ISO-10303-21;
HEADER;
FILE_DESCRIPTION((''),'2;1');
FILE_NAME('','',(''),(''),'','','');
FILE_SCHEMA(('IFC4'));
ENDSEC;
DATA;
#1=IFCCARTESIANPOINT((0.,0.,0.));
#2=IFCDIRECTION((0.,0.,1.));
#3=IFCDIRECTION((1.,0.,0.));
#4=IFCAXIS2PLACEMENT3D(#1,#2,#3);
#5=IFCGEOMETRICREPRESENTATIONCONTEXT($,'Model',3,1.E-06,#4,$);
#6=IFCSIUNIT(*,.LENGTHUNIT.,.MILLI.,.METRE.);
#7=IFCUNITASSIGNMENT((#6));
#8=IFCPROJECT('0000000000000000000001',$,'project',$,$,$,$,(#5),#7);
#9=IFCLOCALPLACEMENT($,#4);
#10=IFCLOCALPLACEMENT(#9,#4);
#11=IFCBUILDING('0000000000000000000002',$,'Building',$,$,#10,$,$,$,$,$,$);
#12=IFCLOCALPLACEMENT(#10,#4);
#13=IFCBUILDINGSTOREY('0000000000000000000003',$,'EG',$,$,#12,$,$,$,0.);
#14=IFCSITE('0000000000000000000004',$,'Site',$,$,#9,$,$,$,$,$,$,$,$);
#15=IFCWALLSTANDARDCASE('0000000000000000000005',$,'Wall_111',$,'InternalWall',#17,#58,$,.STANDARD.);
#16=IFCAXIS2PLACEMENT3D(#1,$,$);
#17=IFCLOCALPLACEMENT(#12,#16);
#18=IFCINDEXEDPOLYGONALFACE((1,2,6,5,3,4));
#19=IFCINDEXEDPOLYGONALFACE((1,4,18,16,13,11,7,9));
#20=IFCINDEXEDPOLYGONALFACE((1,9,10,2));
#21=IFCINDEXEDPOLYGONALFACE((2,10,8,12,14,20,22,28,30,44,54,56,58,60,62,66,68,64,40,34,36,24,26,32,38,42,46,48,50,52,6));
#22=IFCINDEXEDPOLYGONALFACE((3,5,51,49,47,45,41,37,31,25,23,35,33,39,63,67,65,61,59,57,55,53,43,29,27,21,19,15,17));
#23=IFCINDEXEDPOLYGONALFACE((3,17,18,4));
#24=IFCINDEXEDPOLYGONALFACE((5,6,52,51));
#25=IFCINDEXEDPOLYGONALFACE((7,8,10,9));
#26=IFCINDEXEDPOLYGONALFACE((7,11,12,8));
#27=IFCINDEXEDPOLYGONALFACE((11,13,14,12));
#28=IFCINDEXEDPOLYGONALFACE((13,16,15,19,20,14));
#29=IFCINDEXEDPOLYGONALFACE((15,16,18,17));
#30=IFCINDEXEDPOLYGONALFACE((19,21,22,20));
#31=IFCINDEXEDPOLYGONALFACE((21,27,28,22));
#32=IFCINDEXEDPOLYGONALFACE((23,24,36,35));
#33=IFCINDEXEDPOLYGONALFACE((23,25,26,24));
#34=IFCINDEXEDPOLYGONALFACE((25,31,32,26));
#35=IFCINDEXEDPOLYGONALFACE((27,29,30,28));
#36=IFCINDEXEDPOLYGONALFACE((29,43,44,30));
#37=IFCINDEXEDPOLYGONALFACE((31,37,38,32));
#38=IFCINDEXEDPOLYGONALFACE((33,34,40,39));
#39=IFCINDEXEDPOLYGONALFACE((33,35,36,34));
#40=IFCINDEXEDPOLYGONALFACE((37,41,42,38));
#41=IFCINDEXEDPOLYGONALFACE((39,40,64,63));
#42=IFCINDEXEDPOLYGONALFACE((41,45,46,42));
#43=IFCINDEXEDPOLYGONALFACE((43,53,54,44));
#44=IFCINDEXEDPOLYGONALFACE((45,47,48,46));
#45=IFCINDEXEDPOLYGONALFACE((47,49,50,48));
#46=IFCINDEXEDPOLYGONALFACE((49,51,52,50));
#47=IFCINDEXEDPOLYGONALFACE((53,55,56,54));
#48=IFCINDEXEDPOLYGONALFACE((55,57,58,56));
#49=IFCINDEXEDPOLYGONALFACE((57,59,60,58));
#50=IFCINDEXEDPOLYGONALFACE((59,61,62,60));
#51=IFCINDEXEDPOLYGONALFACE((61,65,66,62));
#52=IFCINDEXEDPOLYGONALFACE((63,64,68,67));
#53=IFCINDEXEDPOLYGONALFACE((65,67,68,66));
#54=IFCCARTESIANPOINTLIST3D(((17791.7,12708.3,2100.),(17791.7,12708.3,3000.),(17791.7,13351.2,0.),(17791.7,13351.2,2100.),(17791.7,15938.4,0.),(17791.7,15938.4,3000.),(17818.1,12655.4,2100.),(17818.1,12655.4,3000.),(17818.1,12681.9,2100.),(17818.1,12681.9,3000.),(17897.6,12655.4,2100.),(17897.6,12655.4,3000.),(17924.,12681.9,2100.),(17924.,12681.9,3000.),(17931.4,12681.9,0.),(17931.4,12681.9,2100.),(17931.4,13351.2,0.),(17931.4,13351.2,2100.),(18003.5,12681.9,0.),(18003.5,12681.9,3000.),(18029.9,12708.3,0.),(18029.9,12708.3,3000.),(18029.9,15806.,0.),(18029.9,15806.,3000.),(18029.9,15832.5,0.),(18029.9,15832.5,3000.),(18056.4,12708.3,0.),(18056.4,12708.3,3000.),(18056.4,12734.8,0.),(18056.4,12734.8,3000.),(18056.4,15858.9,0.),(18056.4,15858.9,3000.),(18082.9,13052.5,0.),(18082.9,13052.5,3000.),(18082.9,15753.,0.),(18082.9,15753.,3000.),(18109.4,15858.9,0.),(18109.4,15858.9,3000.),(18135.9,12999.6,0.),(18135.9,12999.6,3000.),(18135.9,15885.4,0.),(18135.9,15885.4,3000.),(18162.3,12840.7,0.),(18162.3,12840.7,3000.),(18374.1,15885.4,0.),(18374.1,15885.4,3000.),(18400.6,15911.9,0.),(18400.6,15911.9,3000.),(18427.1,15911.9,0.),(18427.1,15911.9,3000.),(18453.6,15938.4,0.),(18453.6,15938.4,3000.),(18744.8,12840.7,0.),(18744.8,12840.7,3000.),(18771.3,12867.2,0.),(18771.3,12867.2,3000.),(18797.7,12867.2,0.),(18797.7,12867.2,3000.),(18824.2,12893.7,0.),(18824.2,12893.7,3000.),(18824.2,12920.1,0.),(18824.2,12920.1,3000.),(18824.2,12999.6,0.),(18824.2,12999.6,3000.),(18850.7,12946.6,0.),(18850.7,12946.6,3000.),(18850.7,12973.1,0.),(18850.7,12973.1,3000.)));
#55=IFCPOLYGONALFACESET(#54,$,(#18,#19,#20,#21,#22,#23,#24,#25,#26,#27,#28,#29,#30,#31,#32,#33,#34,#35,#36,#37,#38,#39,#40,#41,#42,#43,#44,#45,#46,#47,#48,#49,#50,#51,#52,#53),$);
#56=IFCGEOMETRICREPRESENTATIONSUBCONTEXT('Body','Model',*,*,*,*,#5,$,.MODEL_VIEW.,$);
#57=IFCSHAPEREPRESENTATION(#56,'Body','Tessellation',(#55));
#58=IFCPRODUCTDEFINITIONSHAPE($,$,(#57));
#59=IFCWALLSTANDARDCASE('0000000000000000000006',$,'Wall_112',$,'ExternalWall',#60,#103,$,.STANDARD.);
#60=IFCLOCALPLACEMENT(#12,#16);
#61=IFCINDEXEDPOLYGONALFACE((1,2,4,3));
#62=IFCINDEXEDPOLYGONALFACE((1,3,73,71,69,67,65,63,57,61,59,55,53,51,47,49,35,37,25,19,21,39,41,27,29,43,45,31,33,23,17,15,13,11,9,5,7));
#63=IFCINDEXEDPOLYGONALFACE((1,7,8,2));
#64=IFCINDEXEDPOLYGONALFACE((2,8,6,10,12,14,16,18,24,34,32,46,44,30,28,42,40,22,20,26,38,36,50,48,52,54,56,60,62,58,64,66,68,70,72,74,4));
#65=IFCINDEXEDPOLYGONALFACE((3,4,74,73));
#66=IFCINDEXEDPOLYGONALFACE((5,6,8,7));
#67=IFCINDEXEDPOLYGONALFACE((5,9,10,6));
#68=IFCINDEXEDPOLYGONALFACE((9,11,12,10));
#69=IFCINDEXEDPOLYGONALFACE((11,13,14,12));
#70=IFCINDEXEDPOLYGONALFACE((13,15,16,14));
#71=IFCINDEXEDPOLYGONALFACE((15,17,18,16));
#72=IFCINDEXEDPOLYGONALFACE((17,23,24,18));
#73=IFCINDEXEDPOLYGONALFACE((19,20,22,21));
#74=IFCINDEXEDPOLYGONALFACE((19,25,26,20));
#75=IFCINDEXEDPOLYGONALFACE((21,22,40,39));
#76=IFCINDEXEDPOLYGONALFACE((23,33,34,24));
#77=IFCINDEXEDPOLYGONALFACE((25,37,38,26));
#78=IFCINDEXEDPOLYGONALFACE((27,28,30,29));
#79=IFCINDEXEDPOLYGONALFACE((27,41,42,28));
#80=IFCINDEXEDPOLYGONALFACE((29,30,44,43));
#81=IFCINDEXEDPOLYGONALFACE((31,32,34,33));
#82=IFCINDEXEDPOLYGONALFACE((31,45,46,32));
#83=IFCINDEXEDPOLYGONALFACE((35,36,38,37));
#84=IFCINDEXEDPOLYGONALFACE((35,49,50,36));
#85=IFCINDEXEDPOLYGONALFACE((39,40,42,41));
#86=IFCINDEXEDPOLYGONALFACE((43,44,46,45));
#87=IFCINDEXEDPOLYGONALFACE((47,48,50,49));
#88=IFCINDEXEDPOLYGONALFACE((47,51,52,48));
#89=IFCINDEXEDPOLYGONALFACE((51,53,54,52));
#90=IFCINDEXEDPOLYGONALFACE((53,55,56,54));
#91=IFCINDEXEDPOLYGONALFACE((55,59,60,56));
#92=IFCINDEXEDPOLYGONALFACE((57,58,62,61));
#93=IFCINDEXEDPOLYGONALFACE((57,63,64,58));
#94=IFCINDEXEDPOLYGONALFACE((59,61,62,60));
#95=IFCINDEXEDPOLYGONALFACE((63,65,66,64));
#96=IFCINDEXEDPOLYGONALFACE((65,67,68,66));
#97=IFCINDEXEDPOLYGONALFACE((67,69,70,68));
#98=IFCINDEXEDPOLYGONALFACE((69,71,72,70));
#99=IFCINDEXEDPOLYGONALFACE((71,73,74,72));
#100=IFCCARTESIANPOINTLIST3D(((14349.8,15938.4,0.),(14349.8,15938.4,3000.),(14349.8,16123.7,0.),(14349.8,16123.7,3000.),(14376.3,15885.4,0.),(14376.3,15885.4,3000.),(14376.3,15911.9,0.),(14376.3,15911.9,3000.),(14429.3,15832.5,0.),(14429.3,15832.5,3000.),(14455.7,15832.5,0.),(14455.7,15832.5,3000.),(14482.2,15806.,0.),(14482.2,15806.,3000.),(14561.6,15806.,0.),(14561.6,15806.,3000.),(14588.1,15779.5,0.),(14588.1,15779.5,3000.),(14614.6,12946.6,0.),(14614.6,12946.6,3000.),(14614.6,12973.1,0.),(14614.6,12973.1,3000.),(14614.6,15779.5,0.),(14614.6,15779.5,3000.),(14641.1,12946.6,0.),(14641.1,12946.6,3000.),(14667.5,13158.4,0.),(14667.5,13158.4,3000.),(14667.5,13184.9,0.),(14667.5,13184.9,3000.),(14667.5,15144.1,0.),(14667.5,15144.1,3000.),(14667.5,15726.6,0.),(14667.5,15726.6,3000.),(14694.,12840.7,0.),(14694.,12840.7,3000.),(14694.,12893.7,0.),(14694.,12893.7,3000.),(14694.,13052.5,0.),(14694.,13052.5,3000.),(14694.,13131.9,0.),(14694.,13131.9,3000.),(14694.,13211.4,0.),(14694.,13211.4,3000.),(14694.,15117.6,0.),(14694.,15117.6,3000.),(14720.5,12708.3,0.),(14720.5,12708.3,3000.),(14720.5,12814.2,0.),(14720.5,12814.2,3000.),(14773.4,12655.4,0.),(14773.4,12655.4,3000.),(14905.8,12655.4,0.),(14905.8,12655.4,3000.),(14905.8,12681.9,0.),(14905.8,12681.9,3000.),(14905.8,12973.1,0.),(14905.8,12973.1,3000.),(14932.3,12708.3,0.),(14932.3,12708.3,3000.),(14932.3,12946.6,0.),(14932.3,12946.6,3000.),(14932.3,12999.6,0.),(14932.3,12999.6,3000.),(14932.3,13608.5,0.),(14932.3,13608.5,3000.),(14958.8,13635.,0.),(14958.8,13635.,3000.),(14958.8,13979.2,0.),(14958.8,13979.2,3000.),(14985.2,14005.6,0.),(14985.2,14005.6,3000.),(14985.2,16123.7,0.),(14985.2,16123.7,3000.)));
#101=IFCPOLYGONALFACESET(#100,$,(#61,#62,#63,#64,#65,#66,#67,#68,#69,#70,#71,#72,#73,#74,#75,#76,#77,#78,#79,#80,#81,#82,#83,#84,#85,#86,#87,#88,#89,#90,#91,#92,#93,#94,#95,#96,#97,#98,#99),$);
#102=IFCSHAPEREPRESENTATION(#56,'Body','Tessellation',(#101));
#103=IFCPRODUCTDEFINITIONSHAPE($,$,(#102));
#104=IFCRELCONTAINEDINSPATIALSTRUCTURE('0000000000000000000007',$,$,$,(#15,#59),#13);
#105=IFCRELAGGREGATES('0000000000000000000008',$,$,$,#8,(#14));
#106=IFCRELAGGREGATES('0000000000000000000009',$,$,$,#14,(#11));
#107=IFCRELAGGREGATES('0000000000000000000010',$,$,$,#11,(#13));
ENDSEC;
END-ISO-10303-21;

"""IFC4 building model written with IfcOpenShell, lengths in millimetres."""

from ifc_helpers import new_model, si_unit, frame, origin_with_axes, place, context, subcontext, project, spatial, polyline, rectangle, outline, extrude, element, save


model = new_model("IFC4")

# Units and contexts
model_context = context("Model", 3, precision=1e-06, world=origin_with_axes())
body_context = subcontext(model_context, "Body", "Model", "MODEL_VIEW")
ifc_project = project(units=[si_unit("LENGTHUNIT", "METRE", prefix="MILLI")], contexts=[model_context])

# Site, building, storey
site_placement = place(None, origin_with_axes())
site = spatial("IfcSite", under=ifc_project, at=site_placement, Name="Site")
building_placement = place(site_placement, origin_with_axes())
building = spatial("IfcBuilding", under=site, at=building_placement, Name="Building")
storey_placement = place(building_placement, origin_with_axes())
storey = spatial("IfcBuildingStorey", under=building, at=storey_placement, Name="EG", Elevation=0.0)

# Wall, opening
wall_1_placement = place(storey_placement, origin_with_axes())
wall_1 = element("IfcWallStandardCase", 1, at=wall_1_placement, inside=storey, Name="Wall_111", ObjectType="InternalWall", PredefinedType="STANDARD", context=body_context, shape_type="SweptSolid", body=[
    extrude(outline(polyline([(17818.1, 12655.4, 0.0), (17818.1, 12681.9, 0.0), (17791.7, 12708.3, 0.0), (17791.7, 15938.4, 0.0), (18453.6, 15938.4, 0.0), (18427.1, 15911.9, 0.0), (18400.6, 15911.9, 0.0), (18374.1, 15885.4, 0.0), (18135.9, 15885.4, 0.0), (18109.4, 15858.9, 0.0), (18056.4, 15858.9, 0.0), (18029.9, 15832.5, 0.0), (18029.9, 15806.0, 0.0), (18082.9, 15753.0, 0.0), (18082.9, 13052.5, 0.0), (18135.9, 12999.6, 0.0), (18824.2, 12999.6, 0.0), (18850.7, 12973.1, 0.0), (18850.7, 12946.6, 0.0), (18824.2, 12920.1, 0.0), (18824.2, 12893.7, 0.0), (18797.7, 12867.2, 0.0), (18771.3, 12867.2, 0.0), (18744.8, 12840.7, 0.0), (18162.3, 12840.7, 0.0), (18056.4, 12734.8, 0.0), (18056.4, 12708.3, 0.0), (18029.9, 12708.3, 0.0), (18003.5, 12681.9, 0.0), (17924.0, 12681.9, 0.0), (17897.6, 12655.4, 0.0), (17818.1, 12655.4, 0.0)])), origin_with_axes(), (0.0, 0.0, 1.0), 3000.0),
])
opening_1_placement = place(wall_1_placement, origin_with_axes())
element("IfcOpeningElement", 2, at=opening_1_placement, inside=storey, cuts=wall_1, context=body_context, shape_type="SweptSolid", body=[
    extrude(rectangle(XDim=1440.7, YDim=300.0), frame((17781.4, 12630.8, 0.0), z_axis=(0.0, 0.0, 1.0), x_axis=(0.0, 1.0, 0.0)), (0.0, 0.0, 1.0), 2100.0),
])

# Wall
for number, where, z_axis, x_axis, name in (
    (3, (0.0, 0.0, 0.0), (0.0, 0.0, 1.0), (1.0, 0.0, 0.0), "Wall_112"),
):
    element("IfcWallStandardCase", number, at=place(storey_placement, frame(where, z_axis=z_axis, x_axis=x_axis)), inside=storey, Name=name, ObjectType="ExternalWall", PredefinedType="STANDARD", context=body_context, shape_type="SweptSolid", body=[
        extrude(outline(polyline([(14773.4, 12655.4, 0.0), (14720.5, 12708.3, 0.0), (14720.5, 12814.2, 0.0), (14694.0, 12840.7, 0.0), (14694.0, 12893.7, 0.0), (14641.1, 12946.6, 0.0), (14614.6, 12946.6, 0.0), (14614.6, 12973.1, 0.0), (14694.0, 13052.5, 0.0), (14694.0, 13131.9, 0.0), (14667.5, 13158.4, 0.0), (14667.5, 13184.9, 0.0), (14694.0, 13211.4, 0.0), (14694.0, 15117.6, 0.0), (14667.5, 15144.1, 0.0), (14667.5, 15726.6, 0.0), (14614.6, 15779.5, 0.0), (14588.1, 15779.5, 0.0), (14561.6, 15806.0, 0.0), (14482.2, 15806.0, 0.0), (14455.7, 15832.5, 0.0), (14429.3, 15832.5, 0.0), (14376.3, 15885.4, 0.0), (14376.3, 15911.9, 0.0), (14349.8, 15938.4, 0.0), (14349.8, 16123.7, 0.0), (14985.2, 16123.7, 0.0), (14985.2, 14005.6, 0.0), (14958.8, 13979.2, 0.0), (14958.8, 13635.0, 0.0), (14932.3, 13608.5, 0.0), (14932.3, 12999.6, 0.0), (14905.8, 12973.1, 0.0), (14932.3, 12946.6, 0.0), (14932.3, 12708.3, 0.0), (14905.8, 12681.9, 0.0), (14905.8, 12655.4, 0.0), (14773.4, 12655.4, 0.0)])), origin_with_axes(), (0.0, 0.0, 1.0), 3000.0),
    ])

save(model, "model.ifc")
